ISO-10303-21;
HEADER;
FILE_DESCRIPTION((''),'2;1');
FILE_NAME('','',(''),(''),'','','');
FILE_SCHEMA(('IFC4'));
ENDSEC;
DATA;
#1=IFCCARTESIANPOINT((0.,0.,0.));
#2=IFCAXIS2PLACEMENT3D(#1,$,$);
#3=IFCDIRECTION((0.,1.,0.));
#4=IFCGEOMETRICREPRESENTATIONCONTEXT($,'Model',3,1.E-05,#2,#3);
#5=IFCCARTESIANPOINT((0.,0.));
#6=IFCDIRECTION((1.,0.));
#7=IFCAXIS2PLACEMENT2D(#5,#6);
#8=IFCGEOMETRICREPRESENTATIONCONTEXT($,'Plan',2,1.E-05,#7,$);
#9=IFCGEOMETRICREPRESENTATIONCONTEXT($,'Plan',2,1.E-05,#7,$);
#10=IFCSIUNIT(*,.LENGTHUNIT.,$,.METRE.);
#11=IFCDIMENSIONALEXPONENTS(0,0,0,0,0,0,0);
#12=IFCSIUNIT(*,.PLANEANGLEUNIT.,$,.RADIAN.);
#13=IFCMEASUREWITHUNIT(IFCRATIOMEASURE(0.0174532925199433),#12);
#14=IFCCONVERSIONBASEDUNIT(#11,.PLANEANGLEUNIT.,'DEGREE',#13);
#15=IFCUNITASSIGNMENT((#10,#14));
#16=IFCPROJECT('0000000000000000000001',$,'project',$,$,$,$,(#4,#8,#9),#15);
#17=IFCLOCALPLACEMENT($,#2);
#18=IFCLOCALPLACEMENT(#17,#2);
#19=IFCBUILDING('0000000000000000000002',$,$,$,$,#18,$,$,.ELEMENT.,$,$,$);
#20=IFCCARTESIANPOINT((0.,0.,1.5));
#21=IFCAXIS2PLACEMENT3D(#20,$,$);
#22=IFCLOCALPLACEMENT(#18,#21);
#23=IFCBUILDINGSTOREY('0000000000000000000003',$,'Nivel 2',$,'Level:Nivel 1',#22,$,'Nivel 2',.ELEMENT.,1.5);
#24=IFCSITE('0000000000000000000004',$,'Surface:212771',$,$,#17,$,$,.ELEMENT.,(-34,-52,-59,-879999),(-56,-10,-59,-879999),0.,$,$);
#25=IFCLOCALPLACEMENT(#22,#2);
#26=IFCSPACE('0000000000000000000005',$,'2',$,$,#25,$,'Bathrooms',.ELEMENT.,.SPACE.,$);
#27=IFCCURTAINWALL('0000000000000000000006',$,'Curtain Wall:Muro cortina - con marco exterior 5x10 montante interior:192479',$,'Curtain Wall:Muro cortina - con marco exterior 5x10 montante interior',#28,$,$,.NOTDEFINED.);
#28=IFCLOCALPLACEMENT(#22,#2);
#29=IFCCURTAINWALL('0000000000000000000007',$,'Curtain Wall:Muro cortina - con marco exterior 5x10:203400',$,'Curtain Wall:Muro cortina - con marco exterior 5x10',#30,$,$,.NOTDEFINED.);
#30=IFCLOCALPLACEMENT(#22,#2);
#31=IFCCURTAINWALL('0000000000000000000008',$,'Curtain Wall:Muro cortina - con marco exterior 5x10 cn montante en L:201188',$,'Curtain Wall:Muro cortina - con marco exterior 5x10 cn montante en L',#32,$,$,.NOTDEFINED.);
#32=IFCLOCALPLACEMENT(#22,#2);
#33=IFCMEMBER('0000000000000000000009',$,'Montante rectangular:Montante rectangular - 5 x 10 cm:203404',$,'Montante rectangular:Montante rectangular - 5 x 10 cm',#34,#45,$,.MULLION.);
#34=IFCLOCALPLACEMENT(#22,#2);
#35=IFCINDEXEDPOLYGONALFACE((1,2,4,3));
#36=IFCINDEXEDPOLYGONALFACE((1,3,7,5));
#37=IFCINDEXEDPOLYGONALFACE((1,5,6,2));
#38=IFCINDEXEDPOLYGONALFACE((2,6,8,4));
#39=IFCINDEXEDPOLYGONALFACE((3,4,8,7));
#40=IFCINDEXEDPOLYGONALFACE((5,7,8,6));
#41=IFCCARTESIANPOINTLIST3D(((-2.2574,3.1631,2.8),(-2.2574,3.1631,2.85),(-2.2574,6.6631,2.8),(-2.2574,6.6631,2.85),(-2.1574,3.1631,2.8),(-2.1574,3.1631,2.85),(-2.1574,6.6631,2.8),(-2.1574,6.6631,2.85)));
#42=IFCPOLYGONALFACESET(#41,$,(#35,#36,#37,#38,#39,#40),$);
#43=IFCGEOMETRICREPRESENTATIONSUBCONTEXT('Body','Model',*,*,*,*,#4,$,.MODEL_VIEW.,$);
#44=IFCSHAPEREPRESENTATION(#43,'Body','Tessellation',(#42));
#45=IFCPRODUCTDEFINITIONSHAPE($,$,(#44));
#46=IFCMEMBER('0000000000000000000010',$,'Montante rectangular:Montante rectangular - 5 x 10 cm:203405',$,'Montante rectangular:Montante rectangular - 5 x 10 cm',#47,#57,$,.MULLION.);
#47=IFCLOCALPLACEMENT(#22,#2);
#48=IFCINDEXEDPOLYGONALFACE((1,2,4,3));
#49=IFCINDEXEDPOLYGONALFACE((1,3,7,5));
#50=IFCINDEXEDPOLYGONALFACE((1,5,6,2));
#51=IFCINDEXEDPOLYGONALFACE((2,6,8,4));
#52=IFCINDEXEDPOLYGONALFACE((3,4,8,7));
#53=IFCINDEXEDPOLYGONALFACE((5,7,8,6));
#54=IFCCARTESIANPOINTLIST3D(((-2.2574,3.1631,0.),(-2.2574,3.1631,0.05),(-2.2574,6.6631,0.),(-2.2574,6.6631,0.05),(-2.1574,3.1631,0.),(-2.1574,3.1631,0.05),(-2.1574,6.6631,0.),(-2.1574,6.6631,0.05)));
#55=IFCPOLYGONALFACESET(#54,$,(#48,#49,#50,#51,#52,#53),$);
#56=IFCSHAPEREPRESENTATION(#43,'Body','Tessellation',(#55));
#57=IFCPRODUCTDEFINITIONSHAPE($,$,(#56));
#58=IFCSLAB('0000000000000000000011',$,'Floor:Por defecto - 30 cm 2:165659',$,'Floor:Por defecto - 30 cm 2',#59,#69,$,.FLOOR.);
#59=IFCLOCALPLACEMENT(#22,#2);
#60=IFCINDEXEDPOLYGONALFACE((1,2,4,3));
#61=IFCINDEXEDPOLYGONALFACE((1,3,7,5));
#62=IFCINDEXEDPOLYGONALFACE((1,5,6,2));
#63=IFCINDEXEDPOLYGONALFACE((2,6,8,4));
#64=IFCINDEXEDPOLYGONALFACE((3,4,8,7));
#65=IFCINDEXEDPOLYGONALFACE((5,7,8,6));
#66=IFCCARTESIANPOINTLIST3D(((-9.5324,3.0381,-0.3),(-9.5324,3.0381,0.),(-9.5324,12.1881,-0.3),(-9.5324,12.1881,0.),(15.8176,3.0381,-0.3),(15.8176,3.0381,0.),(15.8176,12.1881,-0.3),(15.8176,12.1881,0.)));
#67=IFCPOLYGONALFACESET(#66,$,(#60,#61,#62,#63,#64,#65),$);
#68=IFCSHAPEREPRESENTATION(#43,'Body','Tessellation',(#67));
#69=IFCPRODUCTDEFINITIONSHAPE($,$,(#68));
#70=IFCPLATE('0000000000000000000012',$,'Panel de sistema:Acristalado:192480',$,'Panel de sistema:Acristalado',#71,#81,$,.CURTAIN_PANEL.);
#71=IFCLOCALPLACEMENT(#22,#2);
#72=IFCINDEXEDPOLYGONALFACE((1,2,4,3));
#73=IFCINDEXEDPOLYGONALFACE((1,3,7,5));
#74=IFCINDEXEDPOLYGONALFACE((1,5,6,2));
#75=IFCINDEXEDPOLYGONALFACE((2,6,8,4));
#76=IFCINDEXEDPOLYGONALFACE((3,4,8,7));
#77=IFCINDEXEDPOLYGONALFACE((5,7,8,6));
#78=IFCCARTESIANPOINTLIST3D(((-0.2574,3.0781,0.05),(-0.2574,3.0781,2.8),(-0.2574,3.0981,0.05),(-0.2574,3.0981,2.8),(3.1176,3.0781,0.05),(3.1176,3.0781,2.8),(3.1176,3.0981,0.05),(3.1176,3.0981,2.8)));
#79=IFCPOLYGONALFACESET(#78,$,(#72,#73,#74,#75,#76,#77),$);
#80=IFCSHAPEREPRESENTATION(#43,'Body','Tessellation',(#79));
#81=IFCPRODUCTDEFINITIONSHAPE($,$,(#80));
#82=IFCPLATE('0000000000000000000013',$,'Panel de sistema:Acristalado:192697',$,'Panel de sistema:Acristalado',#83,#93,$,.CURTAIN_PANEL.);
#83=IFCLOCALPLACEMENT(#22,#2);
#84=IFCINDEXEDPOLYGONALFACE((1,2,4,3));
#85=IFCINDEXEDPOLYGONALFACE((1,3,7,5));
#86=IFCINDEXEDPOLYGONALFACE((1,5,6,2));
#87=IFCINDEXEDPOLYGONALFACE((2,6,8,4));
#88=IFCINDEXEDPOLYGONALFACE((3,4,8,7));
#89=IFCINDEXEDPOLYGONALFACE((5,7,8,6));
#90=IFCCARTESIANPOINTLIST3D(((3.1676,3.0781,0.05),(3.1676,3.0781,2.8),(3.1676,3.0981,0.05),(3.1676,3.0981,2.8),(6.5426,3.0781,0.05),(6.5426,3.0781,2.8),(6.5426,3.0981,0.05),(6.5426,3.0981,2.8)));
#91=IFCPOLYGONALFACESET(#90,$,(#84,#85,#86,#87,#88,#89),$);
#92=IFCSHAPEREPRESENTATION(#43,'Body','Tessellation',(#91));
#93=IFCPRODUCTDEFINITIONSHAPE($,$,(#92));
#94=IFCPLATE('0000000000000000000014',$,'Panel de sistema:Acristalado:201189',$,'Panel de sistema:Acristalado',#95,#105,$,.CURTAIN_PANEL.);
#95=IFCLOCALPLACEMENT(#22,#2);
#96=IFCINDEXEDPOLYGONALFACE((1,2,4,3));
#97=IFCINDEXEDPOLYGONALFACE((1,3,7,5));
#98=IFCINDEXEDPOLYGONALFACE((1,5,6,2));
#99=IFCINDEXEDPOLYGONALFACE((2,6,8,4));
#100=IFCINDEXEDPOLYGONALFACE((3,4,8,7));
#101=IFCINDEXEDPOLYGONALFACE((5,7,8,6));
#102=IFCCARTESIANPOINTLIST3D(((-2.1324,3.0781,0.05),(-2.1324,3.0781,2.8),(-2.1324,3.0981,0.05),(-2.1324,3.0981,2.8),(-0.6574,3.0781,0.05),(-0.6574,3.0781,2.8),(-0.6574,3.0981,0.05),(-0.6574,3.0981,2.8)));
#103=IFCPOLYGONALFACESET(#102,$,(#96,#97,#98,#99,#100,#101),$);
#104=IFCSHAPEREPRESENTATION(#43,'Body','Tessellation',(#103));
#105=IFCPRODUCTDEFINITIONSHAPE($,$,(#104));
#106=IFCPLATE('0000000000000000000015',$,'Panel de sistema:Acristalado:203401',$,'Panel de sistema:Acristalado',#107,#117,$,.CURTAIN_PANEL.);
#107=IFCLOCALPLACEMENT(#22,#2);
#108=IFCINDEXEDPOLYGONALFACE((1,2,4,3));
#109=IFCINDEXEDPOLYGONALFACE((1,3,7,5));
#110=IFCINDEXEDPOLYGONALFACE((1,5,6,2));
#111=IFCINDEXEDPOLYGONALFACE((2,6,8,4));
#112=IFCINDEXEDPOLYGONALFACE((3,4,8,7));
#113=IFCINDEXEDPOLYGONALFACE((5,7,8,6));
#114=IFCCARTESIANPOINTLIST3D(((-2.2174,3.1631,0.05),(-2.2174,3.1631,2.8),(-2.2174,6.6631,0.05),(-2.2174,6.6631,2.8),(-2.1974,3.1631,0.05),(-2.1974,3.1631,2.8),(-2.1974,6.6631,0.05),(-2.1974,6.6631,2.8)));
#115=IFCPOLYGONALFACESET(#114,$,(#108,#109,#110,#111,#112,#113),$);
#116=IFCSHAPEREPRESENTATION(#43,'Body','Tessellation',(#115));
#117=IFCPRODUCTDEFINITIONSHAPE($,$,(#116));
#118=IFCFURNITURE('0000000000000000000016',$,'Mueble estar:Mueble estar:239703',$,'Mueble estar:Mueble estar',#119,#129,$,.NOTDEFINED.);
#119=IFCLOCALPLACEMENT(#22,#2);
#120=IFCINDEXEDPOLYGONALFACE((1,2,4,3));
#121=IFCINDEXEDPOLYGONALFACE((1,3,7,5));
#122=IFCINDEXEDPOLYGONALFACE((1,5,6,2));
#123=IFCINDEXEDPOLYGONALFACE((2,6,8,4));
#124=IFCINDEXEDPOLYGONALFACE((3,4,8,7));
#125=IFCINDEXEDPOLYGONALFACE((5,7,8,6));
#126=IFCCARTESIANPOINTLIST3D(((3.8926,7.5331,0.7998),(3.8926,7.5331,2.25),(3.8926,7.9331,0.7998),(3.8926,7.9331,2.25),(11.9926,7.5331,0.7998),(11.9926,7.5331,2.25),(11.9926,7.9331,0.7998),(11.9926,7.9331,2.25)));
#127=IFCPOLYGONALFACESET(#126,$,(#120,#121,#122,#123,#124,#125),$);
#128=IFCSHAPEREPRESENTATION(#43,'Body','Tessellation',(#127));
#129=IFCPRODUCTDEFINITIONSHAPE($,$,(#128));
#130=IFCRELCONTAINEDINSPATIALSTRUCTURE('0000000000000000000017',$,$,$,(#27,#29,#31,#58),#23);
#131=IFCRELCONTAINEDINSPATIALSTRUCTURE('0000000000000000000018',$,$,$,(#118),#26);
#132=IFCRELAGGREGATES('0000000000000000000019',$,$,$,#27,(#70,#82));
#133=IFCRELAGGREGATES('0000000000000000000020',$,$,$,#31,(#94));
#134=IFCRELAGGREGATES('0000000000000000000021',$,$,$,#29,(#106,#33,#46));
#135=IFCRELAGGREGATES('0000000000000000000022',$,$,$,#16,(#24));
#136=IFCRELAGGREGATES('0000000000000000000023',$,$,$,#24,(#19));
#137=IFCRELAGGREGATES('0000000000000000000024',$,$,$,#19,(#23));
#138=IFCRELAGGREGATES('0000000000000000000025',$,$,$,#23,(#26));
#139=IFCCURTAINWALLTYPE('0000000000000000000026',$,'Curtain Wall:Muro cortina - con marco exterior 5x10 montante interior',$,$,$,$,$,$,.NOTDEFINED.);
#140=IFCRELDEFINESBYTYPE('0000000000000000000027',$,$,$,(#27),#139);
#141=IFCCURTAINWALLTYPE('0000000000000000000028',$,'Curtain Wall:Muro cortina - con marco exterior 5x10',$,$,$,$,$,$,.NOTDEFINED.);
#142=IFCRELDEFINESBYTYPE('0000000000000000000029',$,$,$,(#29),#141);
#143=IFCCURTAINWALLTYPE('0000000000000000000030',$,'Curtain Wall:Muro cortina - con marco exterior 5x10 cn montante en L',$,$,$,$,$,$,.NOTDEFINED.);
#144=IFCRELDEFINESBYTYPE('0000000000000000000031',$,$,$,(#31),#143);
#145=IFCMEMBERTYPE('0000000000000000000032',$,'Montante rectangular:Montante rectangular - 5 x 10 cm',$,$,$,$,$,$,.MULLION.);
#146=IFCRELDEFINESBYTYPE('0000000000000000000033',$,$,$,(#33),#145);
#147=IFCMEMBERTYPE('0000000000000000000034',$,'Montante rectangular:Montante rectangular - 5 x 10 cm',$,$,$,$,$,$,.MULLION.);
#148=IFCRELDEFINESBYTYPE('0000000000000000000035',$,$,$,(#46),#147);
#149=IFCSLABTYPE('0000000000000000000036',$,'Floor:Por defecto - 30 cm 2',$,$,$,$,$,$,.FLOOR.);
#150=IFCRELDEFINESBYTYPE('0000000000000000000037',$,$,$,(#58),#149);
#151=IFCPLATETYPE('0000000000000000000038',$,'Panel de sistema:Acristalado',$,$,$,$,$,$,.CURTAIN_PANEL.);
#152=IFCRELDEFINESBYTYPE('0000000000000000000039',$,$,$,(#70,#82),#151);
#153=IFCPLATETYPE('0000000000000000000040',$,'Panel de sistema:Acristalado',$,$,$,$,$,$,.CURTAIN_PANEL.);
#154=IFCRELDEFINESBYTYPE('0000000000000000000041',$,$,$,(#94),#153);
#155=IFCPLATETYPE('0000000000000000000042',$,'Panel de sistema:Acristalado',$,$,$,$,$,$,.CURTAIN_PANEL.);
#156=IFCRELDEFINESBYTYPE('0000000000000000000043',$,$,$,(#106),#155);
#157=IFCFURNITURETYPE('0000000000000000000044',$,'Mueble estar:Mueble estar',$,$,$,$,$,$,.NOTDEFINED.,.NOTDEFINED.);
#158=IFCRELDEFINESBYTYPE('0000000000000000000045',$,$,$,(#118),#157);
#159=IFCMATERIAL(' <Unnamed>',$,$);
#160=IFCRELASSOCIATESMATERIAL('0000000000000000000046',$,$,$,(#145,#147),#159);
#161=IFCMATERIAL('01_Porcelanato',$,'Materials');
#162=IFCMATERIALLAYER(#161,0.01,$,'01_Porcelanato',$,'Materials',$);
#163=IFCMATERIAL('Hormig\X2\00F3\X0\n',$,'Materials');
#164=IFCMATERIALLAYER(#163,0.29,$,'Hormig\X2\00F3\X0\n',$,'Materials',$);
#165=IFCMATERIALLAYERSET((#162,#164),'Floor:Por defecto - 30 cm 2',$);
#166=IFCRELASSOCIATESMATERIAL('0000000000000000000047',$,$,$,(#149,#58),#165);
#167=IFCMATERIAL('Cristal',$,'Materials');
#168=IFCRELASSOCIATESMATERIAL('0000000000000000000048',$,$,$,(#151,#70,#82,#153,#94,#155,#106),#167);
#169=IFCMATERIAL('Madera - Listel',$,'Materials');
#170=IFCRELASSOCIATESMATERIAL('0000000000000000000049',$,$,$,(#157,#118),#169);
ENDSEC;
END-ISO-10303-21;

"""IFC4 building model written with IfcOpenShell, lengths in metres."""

from ifc_helpers import new_model, entity, si_unit, converted_unit, direction, frame, origin, origin_2d_with_axis, place, context, subcontext, project, spatial, indexed_curve, outline, extrude, shape, source, transform, mapped, material, layer, layer_set, type_object, type_shapes, element, aggregate, save


model = new_model("IFC4")

# Units and contexts
model_context = context("Model", 3, precision=1e-05, world=origin(), true_north=direction((0.0, 1.0, 0.0)))
plan_context_1 = context("Plan", 2, precision=1e-05, world=origin_2d_with_axis())
plan_context_2 = context("Plan", 2, precision=1e-05, world=origin_2d_with_axis())
body_context = subcontext(model_context, "Body", "Model", "MODEL_VIEW")
footprint_context = subcontext(model_context, "FootPrint", "Model", "MODEL_VIEW")
ifc_project = project(units=[si_unit("LENGTHUNIT", "METRE"), converted_unit("PLANEANGLEUNIT", "DEGREE", entity("IfcRatioMeasure", 0.0174532925199433), si_unit("PLANEANGLEUNIT", "RADIAN"), dimensions=[0, 0, 0, 0, 0, 0, 0])], contexts=[model_context, plan_context_1, plan_context_2])

# Site, building, storey
site_placement = place(None, origin())
site = spatial("IfcSite", under=ifc_project, at=site_placement, Name="Surface:212771", CompositionType="ELEMENT", RefLatitude=(-34, -52, -59, -879999), RefLongitude=(-56, -10, -59, -879999), RefElevation=0.0)
building_placement = place(site_placement, origin())
building = spatial("IfcBuilding", under=site, at=building_placement, CompositionType="ELEMENT")
storey_placement = place(building_placement, frame((0.0, 0.0, 1.5)))
storey = spatial("IfcBuildingStorey", under=building, at=storey_placement, Name="Nivel 2", ObjectType="Level:Nivel 1", LongName="Nivel 2", CompositionType="ELEMENT", Elevation=1.5)

# Curtain wall
curtain_wall_type_1 = type_object("IfcCurtainWallType", Name="Curtain Wall:Muro cortina - con marco exterior 5x10 montante interior", PredefinedType="NOTDEFINED")
curtain_wall_1_placement = place(storey_placement, frame((0.0, 0.0, -1.5)))
curtain_wall_1 = element("IfcCurtainWall", 1, at=curtain_wall_1_placement, inside=storey, type_object=curtain_wall_type_1, Name="Curtain Wall:Muro cortina - con marco exterior 5x10 montante interior:192479", ObjectType="Curtain Wall:Muro cortina - con marco exterior 5x10 montante interior", PredefinedType="NOTDEFINED")
ifc_material_1 = material(Name=" <Unnamed>")

# Curtain wall
curtain_wall_type_2 = type_object("IfcCurtainWallType", Name="Curtain Wall:Muro cortina - con marco exterior 5x10", PredefinedType="NOTDEFINED")
curtain_wall_2_placement = place(storey_placement, frame((0.0, 0.0, -1.5)))
curtain_wall_2 = element("IfcCurtainWall", 2, at=curtain_wall_2_placement, inside=storey, type_object=curtain_wall_type_2, Name="Curtain Wall:Muro cortina - con marco exterior 5x10:203400", ObjectType="Curtain Wall:Muro cortina - con marco exterior 5x10", PredefinedType="NOTDEFINED")

# Curtain wall
curtain_wall_type_3 = type_object("IfcCurtainWallType", Name="Curtain Wall:Muro cortina - con marco exterior 5x10 cn montante en L", PredefinedType="NOTDEFINED")
curtain_wall_3_placement = place(storey_placement, frame((0.0, 0.0, -1.5)))
curtain_wall_3 = element("IfcCurtainWall", 3, at=curtain_wall_3_placement, inside=storey, type_object=curtain_wall_type_3, Name="Curtain Wall:Muro cortina - con marco exterior 5x10 cn montante en L:201188", ObjectType="Curtain Wall:Muro cortina - con marco exterior 5x10 cn montante en L", PredefinedType="NOTDEFINED")

# Members
member_type_1 = type_object("IfcMemberType", Name="Montante rectangular:Montante rectangular - 5 x 10 cm", PredefinedType="MULLION", material=ifc_material_1)
shared_shape_1 = source(origin(), body_context, "Body", "SweptSolid", [
    extrude(outline(indexed_curve([(-0.05, -0.025), (0.05, -0.025), (0.05, 0.025), (-0.05, 0.025), (-0.05, -0.025)], self_intersect=False)), frame((-0.025, 0.0, -3.5), z_axis=(0.0, 0.0, 1.0), x_axis=(0.0, -1.0, 0.0)), (0.0, 0.0, 1.0), 3.5),
])
type_shapes(member_type_1, [shared_shape_1])
member_1_placement = place(storey_placement, frame((-2.2074, 6.6631, 2.85), z_axis=(0.0, 1.0, 0.0), x_axis=(0.0, 0.0, 1.0)))
member_1 = element("IfcMember", 4, at=member_1_placement, type_object=member_type_1, Name="Montante rectangular:Montante rectangular - 5 x 10 cm:203404", ObjectType="Montante rectangular:Montante rectangular - 5 x 10 cm", PredefinedType="MULLION", context=body_context, shape_type="MappedRepresentation", body=[
    mapped(shared_shape_1, transform((0.0, 0.0, 0.0), scale=1.0)),
])
member_type_2 = type_object("IfcMemberType", Name="Montante rectangular:Montante rectangular - 5 x 10 cm", PredefinedType="MULLION", material=ifc_material_1)
shared_shape_2 = source(origin(), body_context, "Body", "SweptSolid", [
    extrude(outline(indexed_curve([(-0.05, -0.025), (0.05, -0.025), (0.05, 0.025), (-0.05, 0.025), (-0.05, -0.025)], self_intersect=False)), frame((-0.025, 0.0, -3.5), z_axis=(0.0, 0.0, 1.0), x_axis=(0.0, -1.0, 0.0)), (0.0, 0.0, 1.0), 3.5),
])
type_shapes(member_type_2, [shared_shape_2])
member_2_placement = place(storey_placement, frame((-2.2074, 3.1631, 0.0), z_axis=(0.0, -1.0, 0.0), x_axis=(0.0, 0.0, -1.0)))
member_2 = element("IfcMember", 5, at=member_2_placement, type_object=member_type_2, Name="Montante rectangular:Montante rectangular - 5 x 10 cm:203405", ObjectType="Montante rectangular:Montante rectangular - 5 x 10 cm", PredefinedType="MULLION", context=body_context, shape_type="MappedRepresentation", body=[
    mapped(shared_shape_2, transform((0.0, 0.0, 0.0), scale=1.0)),
])

# Slab
ifc_material_2 = material(Name="01_Porcelanato", Category="Materials")
ifc_layer_1 = layer(ifc_material_2, 0.01, Name="01_Porcelanato", Category="Materials")
ifc_material_3 = material(Name="Hormigón", Category="Materials")
ifc_layer_2 = layer(ifc_material_3, 0.29, Name="Hormigón", Category="Materials")
ifc_layer_set = layer_set([ifc_layer_1, ifc_layer_2], Name="Floor:Por defecto - 30 cm 2")
slab_type = type_object("IfcSlabType", Name="Floor:Por defecto - 30 cm 2", PredefinedType="FLOOR", material=ifc_layer_set)
slab_placement = place(storey_placement, origin())
element("IfcSlab", 6, at=slab_placement, inside=storey, type_object=slab_type, material=ifc_layer_set, Name="Floor:Por defecto - 30 cm 2:165659", ObjectType="Floor:Por defecto - 30 cm 2", PredefinedType="FLOOR", context=body_context, shape_type="SweptSolid", body=[
    extrude(outline(indexed_curve([(-4.575, -12.675), (4.575, -12.675), (4.575, 12.675), (-4.575, 12.675), (-4.575, -12.675)], self_intersect=False)), frame((3.1426, 7.6131, 0.0), z_axis=(0.0, 0.0, -1.0), x_axis=(0.0, 1.0, 0.0)), (0.0, 0.0, 1.0), 0.3),
])

# Plates
ifc_material_4 = material(Name="Cristal", Category="Materials")
plate_type_1 = type_object("IfcPlateType", Name="Panel de sistema:Acristalado", PredefinedType="CURTAIN_PANEL", material=ifc_material_4)
shared_shape_3 = source(origin(), body_context, "Body", "SweptSolid", [
    extrude(outline(indexed_curve([(-0.01, -1.6875), (0.01, -1.6875), (0.01, 1.6875), (-0.01, 1.6875), (-0.01, -1.6875)], self_intersect=False)), frame((0.0, 0.0, 0.0), z_axis=(0.0, 0.0, 1.0), x_axis=(0.0, 1.0, 0.0)), (0.0, 0.0, 1.0), 2.75),
])
shared_shape_4 = source(origin(), footprint_context, "FootPrint", "Curve2D", [
    entity("IfcIndexedPolyCurve", entity("IfcCartesianPointList2D", [[1.6875, -0.01], [1.6875, 0.01], [-1.6875, 0.01], [-1.6875, -0.01], [1.6875, -0.01]]), None, False),
])
type_shapes(plate_type_1, [shared_shape_3, shared_shape_4])
plate_1_placement = place(curtain_wall_1_placement, frame((1.4301, 3.0881, 1.55)))
plate_1 = element("IfcPlate", 7, at=plate_1_placement, type_object=plate_type_1, material=ifc_material_4, Name="Panel de sistema:Acristalado:192480", ObjectType="Panel de sistema:Acristalado", PredefinedType="CURTAIN_PANEL", shapes=[
    shape(body_context, "Body", "MappedRepresentation", [mapped(shared_shape_3, transform((0.0, 0.0, 0.0), scale=1.0))]),
    shape(body_context, "Body", "MappedRepresentation", [mapped(shared_shape_4, transform((0.0, 0.0, 0.0), scale=1.0))]),
])
plate_2_placement = place(curtain_wall_1_placement, frame((4.8551, 3.0881, 1.55)))
plate_2 = element("IfcPlate", 8, at=plate_2_placement, type_object=plate_type_1, material=ifc_material_4, Name="Panel de sistema:Acristalado:192697", ObjectType="Panel de sistema:Acristalado", PredefinedType="CURTAIN_PANEL", shapes=[
    shape(body_context, "Body", "MappedRepresentation", [mapped(shared_shape_3, transform((0.0, 0.0, 0.0), scale=1.0))]),
    shape(body_context, "Body", "MappedRepresentation", [mapped(shared_shape_4, transform((0.0, 0.0, 0.0), scale=1.0))]),
])
aggregate(curtain_wall_1, [plate_1, plate_2])
plate_type_2 = type_object("IfcPlateType", Name="Panel de sistema:Acristalado", PredefinedType="CURTAIN_PANEL", material=ifc_material_4)
shared_shape_5 = source(origin(), body_context, "Body", "SweptSolid", [
    extrude(outline(indexed_curve([(-0.01, -0.7375), (0.01, -0.7375), (0.01, 0.7375), (-0.01, 0.7375), (-0.01, -0.7375)], self_intersect=False)), frame((0.0, 0.0, 0.0), z_axis=(0.0, 0.0, 1.0), x_axis=(0.0, 1.0, 0.0)), (0.0, 0.0, 1.0), 2.75),
])
shared_shape_6 = source(origin(), footprint_context, "FootPrint", "Curve2D", [
    entity("IfcIndexedPolyCurve", entity("IfcCartesianPointList2D", [[0.7375, -0.01], [0.7375, 0.01], [-0.7375, 0.01], [-0.7375, -0.01], [0.7375, -0.01]]), None, False),
])
type_shapes(plate_type_2, [shared_shape_5, shared_shape_6])
plate_3_placement = place(curtain_wall_3_placement, frame((-1.3949, 3.0881, 1.55), z_axis=(0.0, 0.0, 1.0), x_axis=(-1.0, 0.0, 0.0)))
plate_3 = element("IfcPlate", 9, at=plate_3_placement, type_object=plate_type_2, material=ifc_material_4, Name="Panel de sistema:Acristalado:201189", ObjectType="Panel de sistema:Acristalado", PredefinedType="CURTAIN_PANEL", shapes=[
    shape(body_context, "Body", "MappedRepresentation", [mapped(shared_shape_5, transform((0.0, 0.0, 0.0), scale=1.0))]),
    shape(body_context, "Body", "MappedRepresentation", [mapped(shared_shape_6, transform((0.0, 0.0, 0.0), scale=1.0))]),
])
aggregate(curtain_wall_3, [plate_3])
plate_type_3 = type_object("IfcPlateType", Name="Panel de sistema:Acristalado", PredefinedType="CURTAIN_PANEL", material=ifc_material_4)
shared_shape_7 = source(origin(), body_context, "Body", "SweptSolid", [
    extrude(outline(indexed_curve([(-0.01, -1.75), (0.01, -1.75), (0.01, 1.75), (-0.01, 1.75), (-0.01, -1.75)], self_intersect=False)), frame((0.0, 0.0, 0.0), z_axis=(0.0, 0.0, 1.0), x_axis=(0.0, 1.0, 0.0)), (0.0, 0.0, 1.0), 2.75),
])
shared_shape_8 = source(origin(), footprint_context, "FootPrint", "Curve2D", [
    entity("IfcIndexedPolyCurve", entity("IfcCartesianPointList2D", [[1.75, -0.01], [1.75, 0.01], [-1.75, 0.01], [-1.75, -0.01], [1.75, -0.01]]), None, False),
])
type_shapes(plate_type_3, [shared_shape_7, shared_shape_8])
plate_4_placement = place(curtain_wall_2_placement, frame((-2.2074, 4.9131, 1.55), z_axis=(0.0, 0.0, 1.0), x_axis=(0.0, 1.0, 0.0)))
plate_4 = element("IfcPlate", 10, at=plate_4_placement, type_object=plate_type_3, material=ifc_material_4, Name="Panel de sistema:Acristalado:203401", ObjectType="Panel de sistema:Acristalado", PredefinedType="CURTAIN_PANEL", shapes=[
    shape(body_context, "Body", "MappedRepresentation", [mapped(shared_shape_7, transform((0.0, 0.0, 0.0), scale=1.0))]),
    shape(body_context, "Body", "MappedRepresentation", [mapped(shared_shape_8, transform((0.0, 0.0, 0.0), scale=1.0))]),
])
aggregate(curtain_wall_2, [plate_4, member_1, member_2])

# Shared definitions
space_placement = place(storey_placement, origin())
space = spatial("IfcSpace", under=storey, at=space_placement, Name="2", LongName="Bathrooms", CompositionType="ELEMENT", PredefinedType="SPACE")

# Furniture
ifc_material_5 = material(Name="Madera - Listel", Category="Materials")
furniture_type = type_object("IfcFurnitureType", Name="Mueble estar:Mueble estar", AssemblyPlace="NOTDEFINED", PredefinedType="NOTDEFINED", material=ifc_material_5)
shared_shape_9 = source(origin(), body_context, "Body", "SweptSolid", [
    extrude(outline(indexed_curve([(-4.05, -0.2), (4.05, -0.2), (4.05, 0.2), (-4.05, 0.2), (-4.05, -0.2)], self_intersect=False)), frame((7.9426, 7.7331, 2.2998), z_axis=(0.0, 0.0, 1.0), x_axis=(-1.0, 0.0, 0.0)), (0.0, 0.0, 1.0), 1.4502),
])
type_shapes(furniture_type, [shared_shape_9])
furniture_placement = place(space_placement, frame((0.0, 0.0, -1.5)))
element("IfcFurniture", 11, at=furniture_placement, inside=space, type_object=furniture_type, material=ifc_material_5, Name="Mueble estar:Mueble estar:239703", ObjectType="Mueble estar:Mueble estar", PredefinedType="NOTDEFINED", context=body_context, shape_type="MappedRepresentation", body=[
    mapped(shared_shape_9, transform((0.0, 0.0, 0.0), scale=1.0)),
])

save(model, "model.ifc")
